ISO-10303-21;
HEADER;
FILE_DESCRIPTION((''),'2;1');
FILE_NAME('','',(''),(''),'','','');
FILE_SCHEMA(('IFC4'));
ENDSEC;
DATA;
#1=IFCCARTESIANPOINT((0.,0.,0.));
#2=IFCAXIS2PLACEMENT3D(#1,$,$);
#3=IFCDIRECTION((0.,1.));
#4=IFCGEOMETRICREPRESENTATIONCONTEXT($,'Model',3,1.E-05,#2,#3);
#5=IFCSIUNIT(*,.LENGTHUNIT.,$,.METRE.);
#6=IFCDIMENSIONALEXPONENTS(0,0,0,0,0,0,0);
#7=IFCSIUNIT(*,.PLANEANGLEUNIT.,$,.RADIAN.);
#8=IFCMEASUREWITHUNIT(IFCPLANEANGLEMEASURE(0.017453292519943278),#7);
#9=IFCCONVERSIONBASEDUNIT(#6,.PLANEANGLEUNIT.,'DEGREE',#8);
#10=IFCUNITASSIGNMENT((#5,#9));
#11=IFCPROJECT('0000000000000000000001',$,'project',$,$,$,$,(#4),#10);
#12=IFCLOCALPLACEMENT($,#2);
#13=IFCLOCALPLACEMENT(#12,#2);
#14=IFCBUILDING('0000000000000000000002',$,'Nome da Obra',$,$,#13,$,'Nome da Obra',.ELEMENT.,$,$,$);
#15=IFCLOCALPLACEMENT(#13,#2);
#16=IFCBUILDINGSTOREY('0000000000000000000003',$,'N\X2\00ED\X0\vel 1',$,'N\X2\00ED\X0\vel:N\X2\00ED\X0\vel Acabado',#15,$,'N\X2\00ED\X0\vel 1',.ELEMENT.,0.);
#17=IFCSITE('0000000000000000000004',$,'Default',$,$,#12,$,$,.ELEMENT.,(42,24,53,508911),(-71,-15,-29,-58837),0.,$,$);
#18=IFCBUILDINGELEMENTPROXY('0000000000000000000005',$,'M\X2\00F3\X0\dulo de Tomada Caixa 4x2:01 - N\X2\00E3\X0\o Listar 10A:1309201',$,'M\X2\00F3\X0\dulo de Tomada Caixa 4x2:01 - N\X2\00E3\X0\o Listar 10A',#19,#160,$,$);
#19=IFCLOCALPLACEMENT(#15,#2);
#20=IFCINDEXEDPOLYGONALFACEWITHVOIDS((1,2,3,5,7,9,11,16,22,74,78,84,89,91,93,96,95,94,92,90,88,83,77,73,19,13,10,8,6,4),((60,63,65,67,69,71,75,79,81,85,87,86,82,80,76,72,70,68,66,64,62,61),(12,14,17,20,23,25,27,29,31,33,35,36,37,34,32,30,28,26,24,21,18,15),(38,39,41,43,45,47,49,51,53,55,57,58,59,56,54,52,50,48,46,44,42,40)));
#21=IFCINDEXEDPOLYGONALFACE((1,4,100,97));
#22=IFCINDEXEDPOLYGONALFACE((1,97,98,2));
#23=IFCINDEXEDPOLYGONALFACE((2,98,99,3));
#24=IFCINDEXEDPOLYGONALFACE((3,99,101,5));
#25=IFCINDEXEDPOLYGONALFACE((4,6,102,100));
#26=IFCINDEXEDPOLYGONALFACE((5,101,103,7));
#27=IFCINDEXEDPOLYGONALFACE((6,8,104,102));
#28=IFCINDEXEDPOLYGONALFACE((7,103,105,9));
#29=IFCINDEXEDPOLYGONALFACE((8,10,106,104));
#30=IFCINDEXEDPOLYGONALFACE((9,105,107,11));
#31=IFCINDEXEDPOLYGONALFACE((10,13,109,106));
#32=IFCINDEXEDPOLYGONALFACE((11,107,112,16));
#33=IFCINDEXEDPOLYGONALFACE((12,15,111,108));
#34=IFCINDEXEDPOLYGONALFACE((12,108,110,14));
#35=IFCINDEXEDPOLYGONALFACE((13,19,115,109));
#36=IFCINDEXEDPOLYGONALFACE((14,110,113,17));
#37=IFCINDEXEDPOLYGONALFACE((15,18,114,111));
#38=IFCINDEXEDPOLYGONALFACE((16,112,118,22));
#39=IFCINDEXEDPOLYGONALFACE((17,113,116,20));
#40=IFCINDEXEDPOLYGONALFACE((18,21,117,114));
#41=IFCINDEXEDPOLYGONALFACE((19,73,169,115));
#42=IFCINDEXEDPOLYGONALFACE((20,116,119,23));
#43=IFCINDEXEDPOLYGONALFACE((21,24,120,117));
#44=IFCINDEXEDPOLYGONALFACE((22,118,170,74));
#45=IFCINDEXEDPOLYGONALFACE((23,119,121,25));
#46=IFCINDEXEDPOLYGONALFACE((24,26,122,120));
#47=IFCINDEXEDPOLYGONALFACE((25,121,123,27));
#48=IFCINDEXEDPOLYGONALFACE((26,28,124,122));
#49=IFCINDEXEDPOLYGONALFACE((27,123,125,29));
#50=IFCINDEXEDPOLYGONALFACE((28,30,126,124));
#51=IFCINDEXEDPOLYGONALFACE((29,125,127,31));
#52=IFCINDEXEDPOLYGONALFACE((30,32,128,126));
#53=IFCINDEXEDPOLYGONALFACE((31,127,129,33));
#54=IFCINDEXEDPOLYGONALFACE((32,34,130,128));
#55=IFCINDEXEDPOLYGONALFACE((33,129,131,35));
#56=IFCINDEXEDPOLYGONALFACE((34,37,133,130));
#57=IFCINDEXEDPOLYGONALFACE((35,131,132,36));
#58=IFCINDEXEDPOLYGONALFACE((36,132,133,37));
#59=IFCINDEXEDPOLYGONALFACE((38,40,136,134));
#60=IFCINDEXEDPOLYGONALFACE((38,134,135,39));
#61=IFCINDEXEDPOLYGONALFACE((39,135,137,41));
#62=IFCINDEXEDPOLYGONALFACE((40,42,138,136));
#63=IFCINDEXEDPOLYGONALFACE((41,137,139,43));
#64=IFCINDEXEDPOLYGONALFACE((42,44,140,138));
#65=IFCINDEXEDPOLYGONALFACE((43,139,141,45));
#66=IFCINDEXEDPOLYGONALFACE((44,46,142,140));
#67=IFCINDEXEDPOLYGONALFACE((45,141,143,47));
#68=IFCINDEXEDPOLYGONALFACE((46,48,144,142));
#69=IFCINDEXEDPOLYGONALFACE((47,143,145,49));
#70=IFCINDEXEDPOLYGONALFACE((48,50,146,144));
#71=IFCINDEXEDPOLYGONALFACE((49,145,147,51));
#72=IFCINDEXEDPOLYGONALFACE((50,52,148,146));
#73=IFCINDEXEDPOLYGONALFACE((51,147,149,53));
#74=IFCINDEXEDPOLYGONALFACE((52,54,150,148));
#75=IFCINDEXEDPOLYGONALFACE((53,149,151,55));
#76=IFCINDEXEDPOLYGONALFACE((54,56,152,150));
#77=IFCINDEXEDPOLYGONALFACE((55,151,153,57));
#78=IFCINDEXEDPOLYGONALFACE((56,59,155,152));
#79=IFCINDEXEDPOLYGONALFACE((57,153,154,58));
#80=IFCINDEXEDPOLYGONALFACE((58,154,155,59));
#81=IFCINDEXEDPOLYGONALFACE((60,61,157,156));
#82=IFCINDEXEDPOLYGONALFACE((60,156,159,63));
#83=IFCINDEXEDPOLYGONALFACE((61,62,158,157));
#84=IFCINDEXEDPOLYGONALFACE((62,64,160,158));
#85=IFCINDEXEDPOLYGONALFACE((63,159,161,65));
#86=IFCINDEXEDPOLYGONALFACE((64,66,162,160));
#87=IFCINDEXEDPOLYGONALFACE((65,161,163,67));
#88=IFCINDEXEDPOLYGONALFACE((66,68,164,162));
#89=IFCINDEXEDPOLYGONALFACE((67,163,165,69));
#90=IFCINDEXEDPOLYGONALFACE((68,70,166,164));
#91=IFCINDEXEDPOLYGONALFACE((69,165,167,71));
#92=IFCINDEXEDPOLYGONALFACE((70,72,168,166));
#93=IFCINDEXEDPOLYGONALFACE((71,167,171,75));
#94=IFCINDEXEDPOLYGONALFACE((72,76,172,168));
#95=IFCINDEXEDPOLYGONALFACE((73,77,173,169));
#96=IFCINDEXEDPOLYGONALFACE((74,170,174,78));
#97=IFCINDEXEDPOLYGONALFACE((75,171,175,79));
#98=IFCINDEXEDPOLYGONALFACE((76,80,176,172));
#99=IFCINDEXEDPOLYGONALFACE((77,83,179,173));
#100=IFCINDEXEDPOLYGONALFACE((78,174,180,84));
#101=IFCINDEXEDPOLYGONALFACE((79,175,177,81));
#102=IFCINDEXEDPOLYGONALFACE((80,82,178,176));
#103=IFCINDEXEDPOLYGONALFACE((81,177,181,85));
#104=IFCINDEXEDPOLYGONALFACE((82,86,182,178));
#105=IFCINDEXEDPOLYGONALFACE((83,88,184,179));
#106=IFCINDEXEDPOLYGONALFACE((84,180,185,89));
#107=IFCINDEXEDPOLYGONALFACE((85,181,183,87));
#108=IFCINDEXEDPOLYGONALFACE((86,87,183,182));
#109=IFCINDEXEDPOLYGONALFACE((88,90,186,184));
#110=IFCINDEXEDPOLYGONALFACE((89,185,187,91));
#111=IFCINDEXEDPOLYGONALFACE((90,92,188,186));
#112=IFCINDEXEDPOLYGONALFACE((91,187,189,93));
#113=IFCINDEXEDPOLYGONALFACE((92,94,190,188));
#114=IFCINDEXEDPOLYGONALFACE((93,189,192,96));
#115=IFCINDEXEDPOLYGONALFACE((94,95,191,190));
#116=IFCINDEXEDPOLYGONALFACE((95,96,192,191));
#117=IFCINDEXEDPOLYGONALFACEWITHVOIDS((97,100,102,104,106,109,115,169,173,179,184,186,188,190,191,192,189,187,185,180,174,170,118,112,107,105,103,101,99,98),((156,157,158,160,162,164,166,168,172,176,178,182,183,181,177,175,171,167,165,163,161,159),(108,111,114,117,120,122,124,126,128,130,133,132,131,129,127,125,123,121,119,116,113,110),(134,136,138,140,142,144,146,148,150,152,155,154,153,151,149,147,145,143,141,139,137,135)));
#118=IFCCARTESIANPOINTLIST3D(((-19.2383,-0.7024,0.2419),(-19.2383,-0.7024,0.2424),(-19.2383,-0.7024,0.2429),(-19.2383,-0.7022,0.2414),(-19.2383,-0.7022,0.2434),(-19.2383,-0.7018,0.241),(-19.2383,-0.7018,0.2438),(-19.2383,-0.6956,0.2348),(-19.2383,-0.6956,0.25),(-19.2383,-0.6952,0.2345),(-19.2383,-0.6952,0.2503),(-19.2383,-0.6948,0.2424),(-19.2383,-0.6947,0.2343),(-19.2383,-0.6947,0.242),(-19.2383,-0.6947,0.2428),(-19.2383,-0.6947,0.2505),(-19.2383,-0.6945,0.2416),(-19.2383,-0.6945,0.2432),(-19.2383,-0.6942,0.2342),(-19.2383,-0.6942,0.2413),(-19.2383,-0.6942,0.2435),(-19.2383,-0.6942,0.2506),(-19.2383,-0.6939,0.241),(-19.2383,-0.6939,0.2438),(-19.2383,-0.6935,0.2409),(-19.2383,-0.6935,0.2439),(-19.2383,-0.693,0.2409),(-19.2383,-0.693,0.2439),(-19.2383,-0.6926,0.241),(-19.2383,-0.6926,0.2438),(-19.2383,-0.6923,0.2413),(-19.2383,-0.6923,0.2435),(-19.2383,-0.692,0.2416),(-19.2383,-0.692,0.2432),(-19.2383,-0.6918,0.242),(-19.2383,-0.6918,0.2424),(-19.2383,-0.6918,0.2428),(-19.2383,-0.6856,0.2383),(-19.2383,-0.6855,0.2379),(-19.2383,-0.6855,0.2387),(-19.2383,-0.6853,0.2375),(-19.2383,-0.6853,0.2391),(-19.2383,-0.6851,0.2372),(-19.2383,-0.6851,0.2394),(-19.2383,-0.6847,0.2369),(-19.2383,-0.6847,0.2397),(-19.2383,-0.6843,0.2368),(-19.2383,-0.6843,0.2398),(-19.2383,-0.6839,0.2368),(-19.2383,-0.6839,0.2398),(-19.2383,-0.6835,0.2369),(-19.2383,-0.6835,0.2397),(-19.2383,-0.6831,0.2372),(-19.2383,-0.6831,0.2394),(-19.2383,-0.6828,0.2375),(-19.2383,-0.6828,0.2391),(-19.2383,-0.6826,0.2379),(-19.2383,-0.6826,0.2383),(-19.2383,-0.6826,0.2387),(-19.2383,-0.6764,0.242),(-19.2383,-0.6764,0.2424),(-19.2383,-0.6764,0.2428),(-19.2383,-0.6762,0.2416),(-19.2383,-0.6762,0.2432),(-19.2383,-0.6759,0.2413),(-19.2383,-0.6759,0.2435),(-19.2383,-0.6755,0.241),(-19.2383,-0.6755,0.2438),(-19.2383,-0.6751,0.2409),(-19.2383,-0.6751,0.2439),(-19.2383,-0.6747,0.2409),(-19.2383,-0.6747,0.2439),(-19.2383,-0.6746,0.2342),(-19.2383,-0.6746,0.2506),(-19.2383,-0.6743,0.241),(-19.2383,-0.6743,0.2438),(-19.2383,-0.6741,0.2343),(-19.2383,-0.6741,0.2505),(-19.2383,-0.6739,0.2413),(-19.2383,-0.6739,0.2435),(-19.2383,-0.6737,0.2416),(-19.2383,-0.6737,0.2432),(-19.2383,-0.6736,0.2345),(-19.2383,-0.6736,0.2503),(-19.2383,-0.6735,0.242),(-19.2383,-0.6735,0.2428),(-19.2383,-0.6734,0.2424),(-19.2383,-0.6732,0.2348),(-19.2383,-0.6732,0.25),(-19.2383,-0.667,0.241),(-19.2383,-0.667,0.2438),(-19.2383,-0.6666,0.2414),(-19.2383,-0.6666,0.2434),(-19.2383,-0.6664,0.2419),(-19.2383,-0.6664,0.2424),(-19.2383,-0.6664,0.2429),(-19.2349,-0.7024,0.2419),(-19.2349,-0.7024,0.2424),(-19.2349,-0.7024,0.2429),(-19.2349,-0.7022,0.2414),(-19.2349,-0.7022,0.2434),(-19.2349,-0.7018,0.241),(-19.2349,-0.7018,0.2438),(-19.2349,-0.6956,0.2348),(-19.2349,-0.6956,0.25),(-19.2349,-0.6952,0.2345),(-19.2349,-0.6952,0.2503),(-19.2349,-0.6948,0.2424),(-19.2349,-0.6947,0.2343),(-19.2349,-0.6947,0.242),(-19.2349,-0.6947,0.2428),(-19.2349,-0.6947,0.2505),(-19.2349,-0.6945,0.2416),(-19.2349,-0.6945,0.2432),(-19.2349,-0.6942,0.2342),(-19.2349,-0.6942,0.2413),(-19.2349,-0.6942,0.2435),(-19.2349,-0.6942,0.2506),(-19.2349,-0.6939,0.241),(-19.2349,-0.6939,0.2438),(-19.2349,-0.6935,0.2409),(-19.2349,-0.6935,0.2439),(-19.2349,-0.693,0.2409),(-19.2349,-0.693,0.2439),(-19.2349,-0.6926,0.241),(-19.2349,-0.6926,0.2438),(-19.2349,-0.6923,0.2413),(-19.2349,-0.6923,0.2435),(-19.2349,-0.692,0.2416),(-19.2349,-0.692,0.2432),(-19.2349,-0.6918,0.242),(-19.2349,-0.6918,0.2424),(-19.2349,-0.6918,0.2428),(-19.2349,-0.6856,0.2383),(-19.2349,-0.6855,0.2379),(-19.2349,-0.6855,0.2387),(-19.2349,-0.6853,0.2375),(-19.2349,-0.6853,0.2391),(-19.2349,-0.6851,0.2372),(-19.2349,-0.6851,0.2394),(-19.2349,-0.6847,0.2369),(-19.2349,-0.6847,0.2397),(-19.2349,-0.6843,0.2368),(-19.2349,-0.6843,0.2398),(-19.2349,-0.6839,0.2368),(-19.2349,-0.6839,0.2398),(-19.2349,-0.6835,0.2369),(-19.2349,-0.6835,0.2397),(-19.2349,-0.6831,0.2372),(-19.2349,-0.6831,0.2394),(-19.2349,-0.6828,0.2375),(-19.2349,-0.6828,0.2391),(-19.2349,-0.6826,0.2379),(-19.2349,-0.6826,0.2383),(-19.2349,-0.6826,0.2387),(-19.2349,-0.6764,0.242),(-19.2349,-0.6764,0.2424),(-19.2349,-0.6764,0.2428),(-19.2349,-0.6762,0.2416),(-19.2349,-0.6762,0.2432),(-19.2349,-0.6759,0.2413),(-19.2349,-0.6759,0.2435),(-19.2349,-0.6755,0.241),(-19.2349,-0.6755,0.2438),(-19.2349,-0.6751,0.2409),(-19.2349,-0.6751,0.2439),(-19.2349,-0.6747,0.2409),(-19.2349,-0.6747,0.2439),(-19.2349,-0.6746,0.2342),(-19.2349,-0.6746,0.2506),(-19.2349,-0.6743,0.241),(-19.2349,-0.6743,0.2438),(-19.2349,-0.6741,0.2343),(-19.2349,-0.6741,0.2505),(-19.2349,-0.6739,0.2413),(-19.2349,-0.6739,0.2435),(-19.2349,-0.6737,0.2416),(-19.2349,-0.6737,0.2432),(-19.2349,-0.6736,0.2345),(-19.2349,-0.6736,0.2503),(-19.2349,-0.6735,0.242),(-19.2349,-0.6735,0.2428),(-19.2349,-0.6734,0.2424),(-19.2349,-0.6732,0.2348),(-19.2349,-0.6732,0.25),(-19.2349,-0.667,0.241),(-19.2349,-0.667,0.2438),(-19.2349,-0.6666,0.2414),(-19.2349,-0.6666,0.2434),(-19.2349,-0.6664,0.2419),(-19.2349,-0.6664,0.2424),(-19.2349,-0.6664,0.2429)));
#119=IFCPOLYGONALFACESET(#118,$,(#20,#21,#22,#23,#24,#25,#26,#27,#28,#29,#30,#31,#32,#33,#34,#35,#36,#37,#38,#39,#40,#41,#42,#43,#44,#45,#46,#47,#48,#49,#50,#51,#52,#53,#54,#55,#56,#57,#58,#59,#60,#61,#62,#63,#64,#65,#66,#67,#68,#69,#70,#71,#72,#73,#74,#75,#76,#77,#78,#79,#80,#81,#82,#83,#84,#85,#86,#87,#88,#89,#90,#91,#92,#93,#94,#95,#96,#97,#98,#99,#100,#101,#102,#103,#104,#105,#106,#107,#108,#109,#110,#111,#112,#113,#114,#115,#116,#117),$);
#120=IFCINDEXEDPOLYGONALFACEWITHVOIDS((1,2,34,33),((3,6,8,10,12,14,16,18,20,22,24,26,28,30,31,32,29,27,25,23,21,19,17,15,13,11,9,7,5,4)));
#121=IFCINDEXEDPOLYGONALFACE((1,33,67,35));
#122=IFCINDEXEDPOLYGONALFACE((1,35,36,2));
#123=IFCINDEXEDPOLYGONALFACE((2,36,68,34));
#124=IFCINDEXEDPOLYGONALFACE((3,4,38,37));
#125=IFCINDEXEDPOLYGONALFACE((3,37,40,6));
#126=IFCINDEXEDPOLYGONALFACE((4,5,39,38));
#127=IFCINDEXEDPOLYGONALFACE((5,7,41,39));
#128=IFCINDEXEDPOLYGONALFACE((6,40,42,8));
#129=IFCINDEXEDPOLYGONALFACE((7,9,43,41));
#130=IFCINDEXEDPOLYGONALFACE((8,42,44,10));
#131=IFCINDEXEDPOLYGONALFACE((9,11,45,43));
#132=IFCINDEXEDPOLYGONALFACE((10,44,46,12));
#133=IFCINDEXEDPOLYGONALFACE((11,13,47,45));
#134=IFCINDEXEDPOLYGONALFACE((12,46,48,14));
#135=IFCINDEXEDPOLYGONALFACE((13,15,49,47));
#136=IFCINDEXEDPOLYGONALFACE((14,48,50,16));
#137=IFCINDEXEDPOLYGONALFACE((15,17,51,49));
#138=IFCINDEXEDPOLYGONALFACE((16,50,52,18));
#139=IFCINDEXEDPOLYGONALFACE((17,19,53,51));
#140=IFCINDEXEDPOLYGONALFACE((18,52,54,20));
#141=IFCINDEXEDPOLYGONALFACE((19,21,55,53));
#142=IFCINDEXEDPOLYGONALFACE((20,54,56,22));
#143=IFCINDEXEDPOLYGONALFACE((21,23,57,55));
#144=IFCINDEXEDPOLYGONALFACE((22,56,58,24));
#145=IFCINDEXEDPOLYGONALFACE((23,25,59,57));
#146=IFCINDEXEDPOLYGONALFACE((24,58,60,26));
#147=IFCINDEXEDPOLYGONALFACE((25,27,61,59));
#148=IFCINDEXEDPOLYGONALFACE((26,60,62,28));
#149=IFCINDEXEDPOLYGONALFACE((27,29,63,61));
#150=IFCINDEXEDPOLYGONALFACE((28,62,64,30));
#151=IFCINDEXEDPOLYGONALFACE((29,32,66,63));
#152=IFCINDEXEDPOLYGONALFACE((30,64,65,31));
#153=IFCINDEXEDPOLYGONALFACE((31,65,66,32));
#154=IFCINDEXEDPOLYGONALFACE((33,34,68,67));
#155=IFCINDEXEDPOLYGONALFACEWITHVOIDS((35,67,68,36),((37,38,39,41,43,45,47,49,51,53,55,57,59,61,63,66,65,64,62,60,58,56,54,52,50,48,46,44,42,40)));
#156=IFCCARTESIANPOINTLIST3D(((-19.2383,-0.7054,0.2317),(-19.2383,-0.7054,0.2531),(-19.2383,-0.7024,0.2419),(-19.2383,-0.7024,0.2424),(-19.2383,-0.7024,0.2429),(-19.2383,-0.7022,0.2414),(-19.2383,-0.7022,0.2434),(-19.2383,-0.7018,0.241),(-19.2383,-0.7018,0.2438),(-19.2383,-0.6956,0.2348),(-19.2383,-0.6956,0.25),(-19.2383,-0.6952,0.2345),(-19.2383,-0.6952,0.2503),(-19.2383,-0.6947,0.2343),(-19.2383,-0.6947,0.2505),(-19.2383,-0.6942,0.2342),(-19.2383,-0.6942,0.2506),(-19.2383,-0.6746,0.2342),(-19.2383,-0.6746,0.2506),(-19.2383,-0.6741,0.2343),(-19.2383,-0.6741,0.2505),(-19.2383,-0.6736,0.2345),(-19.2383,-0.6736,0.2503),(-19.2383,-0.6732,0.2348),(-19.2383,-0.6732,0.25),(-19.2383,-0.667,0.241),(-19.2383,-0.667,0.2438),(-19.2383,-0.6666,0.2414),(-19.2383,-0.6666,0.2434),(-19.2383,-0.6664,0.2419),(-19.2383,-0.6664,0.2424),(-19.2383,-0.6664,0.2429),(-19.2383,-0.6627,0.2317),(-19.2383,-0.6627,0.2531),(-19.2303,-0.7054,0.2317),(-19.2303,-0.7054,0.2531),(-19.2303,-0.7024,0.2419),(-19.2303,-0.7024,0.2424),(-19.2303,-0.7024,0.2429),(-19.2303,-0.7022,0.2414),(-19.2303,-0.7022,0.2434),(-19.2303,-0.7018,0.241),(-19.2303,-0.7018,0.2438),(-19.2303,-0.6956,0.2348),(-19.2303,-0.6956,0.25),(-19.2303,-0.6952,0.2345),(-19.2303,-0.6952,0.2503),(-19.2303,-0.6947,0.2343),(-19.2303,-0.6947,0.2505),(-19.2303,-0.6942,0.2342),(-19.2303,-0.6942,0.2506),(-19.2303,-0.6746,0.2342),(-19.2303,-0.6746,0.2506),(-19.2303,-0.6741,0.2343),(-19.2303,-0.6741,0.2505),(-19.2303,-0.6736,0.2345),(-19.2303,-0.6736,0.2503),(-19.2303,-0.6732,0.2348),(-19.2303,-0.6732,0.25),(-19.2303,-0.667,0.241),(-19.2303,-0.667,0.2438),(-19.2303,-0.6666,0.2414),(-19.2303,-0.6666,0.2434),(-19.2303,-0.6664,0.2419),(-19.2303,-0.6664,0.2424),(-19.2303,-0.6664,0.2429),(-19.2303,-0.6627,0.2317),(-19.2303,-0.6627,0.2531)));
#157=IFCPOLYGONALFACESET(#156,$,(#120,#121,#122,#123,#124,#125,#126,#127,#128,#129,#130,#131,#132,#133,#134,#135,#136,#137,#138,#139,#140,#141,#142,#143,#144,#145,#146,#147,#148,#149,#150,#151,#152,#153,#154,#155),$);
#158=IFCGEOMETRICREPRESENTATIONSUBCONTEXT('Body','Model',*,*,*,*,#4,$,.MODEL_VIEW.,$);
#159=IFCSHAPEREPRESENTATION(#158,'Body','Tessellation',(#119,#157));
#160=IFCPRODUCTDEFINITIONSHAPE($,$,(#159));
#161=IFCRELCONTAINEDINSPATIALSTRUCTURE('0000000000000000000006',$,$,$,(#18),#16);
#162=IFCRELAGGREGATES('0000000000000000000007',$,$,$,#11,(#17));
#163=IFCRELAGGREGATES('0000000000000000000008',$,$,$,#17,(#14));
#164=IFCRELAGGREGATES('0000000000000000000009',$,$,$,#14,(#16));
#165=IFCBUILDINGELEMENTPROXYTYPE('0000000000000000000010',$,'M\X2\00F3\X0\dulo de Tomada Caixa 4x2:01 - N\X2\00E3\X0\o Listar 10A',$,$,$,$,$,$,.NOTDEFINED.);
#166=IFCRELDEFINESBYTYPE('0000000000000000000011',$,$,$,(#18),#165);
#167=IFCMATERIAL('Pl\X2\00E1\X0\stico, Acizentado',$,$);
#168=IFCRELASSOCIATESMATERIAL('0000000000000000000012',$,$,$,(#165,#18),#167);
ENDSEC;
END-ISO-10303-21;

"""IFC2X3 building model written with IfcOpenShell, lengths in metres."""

from ifc_helpers import new_model, entity, si_unit, converted_unit, direction, frame, frame_2d, origin, place, context, subcontext, project, spatial, polyline, circle_curve, parameter, trimmed, segment, composite_curve, outline, extrude, source, transform, mapped, material, type_object, type_shapes, element, save


model = new_model("IFC2X3")

# Units and contexts
model_context = context("Model", 3, precision=1e-05, world=origin(), true_north=direction((0.0, 1.0)))
body_context = subcontext(model_context, "Body", "Model", "MODEL_VIEW")
ifc_project = project(units=[si_unit("LENGTHUNIT", "METRE"), converted_unit("PLANEANGLEUNIT", "DEGREE", entity("IfcPlaneAngleMeasure", 0.017453292519943278), si_unit("PLANEANGLEUNIT", "RADIAN"), dimensions=[0, 0, 0, 0, 0, 0, 0])], contexts=[model_context])

# Site, building, storey
site_placement = place(None, origin())
site = spatial("IfcSite", under=ifc_project, at=site_placement, Name="Default", CompositionType="ELEMENT", RefLatitude=(42, 24, 53, 508911), RefLongitude=(-71, -15, -29, -58837), RefElevation=0.0)
building_placement = place(site_placement, origin())
building = spatial("IfcBuilding", under=site, at=building_placement, Name="Nome da Obra", LongName="Nome da Obra", CompositionType="ELEMENT")
storey_placement = place(building_placement, origin())
storey = spatial("IfcBuildingStorey", under=building, at=storey_placement, Name="Nível 1", ObjectType="Nível:Nível Acabado", LongName="Nível 1", CompositionType="ELEMENT", Elevation=0.0)

# Building element proxy
ifc_material_1 = material(Name="Plástico, Acizentado")
building_element_proxy_type_1 = type_object("IfcBuildingElementProxyType", Name="Módulo de Tomada Caixa 4x2:01 - Não Listar 10A", PredefinedType="NOTDEFINED", material=ifc_material_1)
shared_shape_1 = source(origin(), body_context, "Body", "SweptSolid", [
    extrude(outline(composite_curve([segment(polyline([(-0.0098, -0.0082), (0.0098, -0.0082)]), True, "CONTINUOUS"), segment(trimmed(circle_curve(frame_2d((0.0098, -0.0062), x_axis=(1.0, 0.0)), 0.002), [parameter(270.0)], [parameter(315.0)], True, "PARAMETER"), True, "CONTINUOUS"), segment(polyline([(0.0112, -0.0076), (0.0174, -0.0014)]), True, "CONTINUOUS"), segment(trimmed(circle_curve(frame_2d((0.016, 0.0), x_axis=(1.0, 0.0)), 0.002), [parameter(315.0)], [parameter(45.0)], True, "PARAMETER"), True, "CONTINUOUS"), segment(polyline([(0.0174, 0.0014), (0.0112, 0.0076)]), True, "CONTINUOUS"), segment(trimmed(circle_curve(frame_2d((0.0098, 0.0062), x_axis=(1.0, 0.0)), 0.002), [parameter(45.0)], [parameter(90.0)], True, "PARAMETER"), True, "CONTINUOUS"), segment(polyline([(0.0098, 0.0082), (-0.0098, 0.0082)]), True, "CONTINUOUS"), segment(trimmed(circle_curve(frame_2d((-0.0098, 0.0062), x_axis=(1.0, 0.0)), 0.002), [parameter(90.0)], [parameter(135.0)], True, "PARAMETER"), True, "CONTINUOUS"), segment(polyline([(-0.0112, 0.0076), (-0.0174, 0.0014)]), True, "CONTINUOUS"), segment(trimmed(circle_curve(frame_2d((-0.016, 0.0), x_axis=(1.0, 0.0)), 0.002), [parameter(135.0)], [parameter(225.0)], True, "PARAMETER"), True, "CONTINUOUS"), segment(polyline([(-0.0174, -0.0014), (-0.0112, -0.0076)]), True, "CONTINUOUS"), segment(trimmed(circle_curve(frame_2d((-0.0098, -0.0062), x_axis=(1.0, 0.0)), 0.002), [parameter(225.0)], [parameter(270.0)], True, "PARAMETER"), True, "CONTINUOUS")], self_intersect=False), holes=[composite_curve([segment(trimmed(circle_curve(frame_2d((0.0089, 0.0), x_axis=(1.0, 0.0)), 0.0015), [parameter(0.0)], [parameter(180.0)], True, "PARAMETER"), False, "CONTINUOUS"), segment(trimmed(circle_curve(frame_2d((0.0089, 0.0), x_axis=(1.0, 0.0)), 0.0015), [parameter(180.0)], [parameter(0.0)], True, "PARAMETER"), False, "CONTINUOUS")], self_intersect=False), composite_curve([segment(trimmed(circle_curve(frame_2d((-0.0003, 0.0041), x_axis=(1.0, 0.0)), 0.0015), [parameter(0.0)], [parameter(180.0)], True, "PARAMETER"), False, "CONTINUOUS"), segment(trimmed(circle_curve(frame_2d((-0.0003, 0.0041), x_axis=(1.0, 0.0)), 0.0015), [parameter(180.0)], [parameter(0.0)], True, "PARAMETER"), False, "CONTINUOUS")], self_intersect=False), composite_curve([segment(trimmed(circle_curve(frame_2d((-0.0095, 0.0), x_axis=(1.0, 0.0)), 0.0015), [parameter(0.0)], [parameter(180.0)], True, "PARAMETER"), False, "CONTINUOUS"), segment(trimmed(circle_curve(frame_2d((-0.0095, 0.0), x_axis=(1.0, 0.0)), 0.0015), [parameter(180.0)], [parameter(0.0)], True, "PARAMETER"), False, "CONTINUOUS")], self_intersect=False)]), frame((0.0003, 0.0, 0.125), z_axis=(0.0, 1.0, 0.0), x_axis=(1.0, 0.0, 0.0)), (0.0, 0.0, 1.0), 0.0034),
    extrude(outline(polyline([(-0.0214, -0.0107), (0.0214, -0.0107), (0.0214, 0.0107), (-0.0214, 0.0107), (-0.0214, -0.0107)]), holes=[composite_curve([segment(polyline([(0.0101, -0.0082), (-0.0095, -0.0082)]), True, "CONTINUOUS"), segment(trimmed(circle_curve(frame_2d((-0.0095, -0.0062), x_axis=(1.0, 0.0)), 0.002), [parameter(225.0)], [parameter(270.0)], True, "PARAMETER"), False, "CONTINUOUS"), segment(polyline([(-0.0109, -0.0076), (-0.0171, -0.0014)]), True, "CONTINUOUS"), segment(trimmed(circle_curve(frame_2d((-0.0157, 0.0), x_axis=(1.0, 0.0)), 0.002), [parameter(135.0)], [parameter(225.0)], True, "PARAMETER"), False, "CONTINUOUS"), segment(polyline([(-0.0171, 0.0014), (-0.0109, 0.0076)]), True, "CONTINUOUS"), segment(trimmed(circle_curve(frame_2d((-0.0095, 0.0062), x_axis=(1.0, 0.0)), 0.002), [parameter(90.0)], [parameter(135.0)], True, "PARAMETER"), False, "CONTINUOUS"), segment(polyline([(-0.0095, 0.0082), (0.0101, 0.0082)]), True, "CONTINUOUS"), segment(trimmed(circle_curve(frame_2d((0.0101, 0.0062), x_axis=(1.0, 0.0)), 0.002), [parameter(45.0)], [parameter(90.0)], True, "PARAMETER"), False, "CONTINUOUS"), segment(polyline([(0.0115, 0.0076), (0.0177, 0.0014)]), True, "CONTINUOUS"), segment(trimmed(circle_curve(frame_2d((0.0163, 0.0), x_axis=(1.0, 0.0)), 0.002), [parameter(315.0)], [parameter(45.0)], True, "PARAMETER"), False, "CONTINUOUS"), segment(polyline([(0.0177, -0.0014), (0.0115, -0.0076)]), True, "CONTINUOUS"), segment(trimmed(circle_curve(frame_2d((0.0101, -0.0062), x_axis=(1.0, 0.0)), 0.002), [parameter(270.0)], [parameter(315.0)], True, "PARAMETER"), False, "CONTINUOUS")], self_intersect=False)]), frame((0.0, 0.0, 0.125), z_axis=(0.0, 1.0, 0.0), x_axis=(1.0, 0.0, 0.0)), (0.0, 0.0, 1.0), 0.008),
])
type_shapes(building_element_proxy_type_1, [shared_shape_1])
for number, where, z_axis, x_axis, name in (
    (1, (-19.2383, -0.6841, 0.1174), (0.0, 0.0, 1.0), (0.0, -1.0, 0.0), "Módulo de Tomada Caixa 4x2:01 - Não Listar 10A:1309201"),
):
    element("IfcBuildingElementProxy", number, at=place(storey_placement, frame(where, z_axis=z_axis, x_axis=x_axis)), inside=storey, type_object=building_element_proxy_type_1, material=ifc_material_1, Name=name, ObjectType="Módulo de Tomada Caixa 4x2:01 - Não Listar 10A", context=body_context, shape_type="MappedRepresentation", body=[
        mapped(shared_shape_1, transform((0.0, 0.0, 0.0), scale=1.0)),
    ])

save(model, "model.ifc")
